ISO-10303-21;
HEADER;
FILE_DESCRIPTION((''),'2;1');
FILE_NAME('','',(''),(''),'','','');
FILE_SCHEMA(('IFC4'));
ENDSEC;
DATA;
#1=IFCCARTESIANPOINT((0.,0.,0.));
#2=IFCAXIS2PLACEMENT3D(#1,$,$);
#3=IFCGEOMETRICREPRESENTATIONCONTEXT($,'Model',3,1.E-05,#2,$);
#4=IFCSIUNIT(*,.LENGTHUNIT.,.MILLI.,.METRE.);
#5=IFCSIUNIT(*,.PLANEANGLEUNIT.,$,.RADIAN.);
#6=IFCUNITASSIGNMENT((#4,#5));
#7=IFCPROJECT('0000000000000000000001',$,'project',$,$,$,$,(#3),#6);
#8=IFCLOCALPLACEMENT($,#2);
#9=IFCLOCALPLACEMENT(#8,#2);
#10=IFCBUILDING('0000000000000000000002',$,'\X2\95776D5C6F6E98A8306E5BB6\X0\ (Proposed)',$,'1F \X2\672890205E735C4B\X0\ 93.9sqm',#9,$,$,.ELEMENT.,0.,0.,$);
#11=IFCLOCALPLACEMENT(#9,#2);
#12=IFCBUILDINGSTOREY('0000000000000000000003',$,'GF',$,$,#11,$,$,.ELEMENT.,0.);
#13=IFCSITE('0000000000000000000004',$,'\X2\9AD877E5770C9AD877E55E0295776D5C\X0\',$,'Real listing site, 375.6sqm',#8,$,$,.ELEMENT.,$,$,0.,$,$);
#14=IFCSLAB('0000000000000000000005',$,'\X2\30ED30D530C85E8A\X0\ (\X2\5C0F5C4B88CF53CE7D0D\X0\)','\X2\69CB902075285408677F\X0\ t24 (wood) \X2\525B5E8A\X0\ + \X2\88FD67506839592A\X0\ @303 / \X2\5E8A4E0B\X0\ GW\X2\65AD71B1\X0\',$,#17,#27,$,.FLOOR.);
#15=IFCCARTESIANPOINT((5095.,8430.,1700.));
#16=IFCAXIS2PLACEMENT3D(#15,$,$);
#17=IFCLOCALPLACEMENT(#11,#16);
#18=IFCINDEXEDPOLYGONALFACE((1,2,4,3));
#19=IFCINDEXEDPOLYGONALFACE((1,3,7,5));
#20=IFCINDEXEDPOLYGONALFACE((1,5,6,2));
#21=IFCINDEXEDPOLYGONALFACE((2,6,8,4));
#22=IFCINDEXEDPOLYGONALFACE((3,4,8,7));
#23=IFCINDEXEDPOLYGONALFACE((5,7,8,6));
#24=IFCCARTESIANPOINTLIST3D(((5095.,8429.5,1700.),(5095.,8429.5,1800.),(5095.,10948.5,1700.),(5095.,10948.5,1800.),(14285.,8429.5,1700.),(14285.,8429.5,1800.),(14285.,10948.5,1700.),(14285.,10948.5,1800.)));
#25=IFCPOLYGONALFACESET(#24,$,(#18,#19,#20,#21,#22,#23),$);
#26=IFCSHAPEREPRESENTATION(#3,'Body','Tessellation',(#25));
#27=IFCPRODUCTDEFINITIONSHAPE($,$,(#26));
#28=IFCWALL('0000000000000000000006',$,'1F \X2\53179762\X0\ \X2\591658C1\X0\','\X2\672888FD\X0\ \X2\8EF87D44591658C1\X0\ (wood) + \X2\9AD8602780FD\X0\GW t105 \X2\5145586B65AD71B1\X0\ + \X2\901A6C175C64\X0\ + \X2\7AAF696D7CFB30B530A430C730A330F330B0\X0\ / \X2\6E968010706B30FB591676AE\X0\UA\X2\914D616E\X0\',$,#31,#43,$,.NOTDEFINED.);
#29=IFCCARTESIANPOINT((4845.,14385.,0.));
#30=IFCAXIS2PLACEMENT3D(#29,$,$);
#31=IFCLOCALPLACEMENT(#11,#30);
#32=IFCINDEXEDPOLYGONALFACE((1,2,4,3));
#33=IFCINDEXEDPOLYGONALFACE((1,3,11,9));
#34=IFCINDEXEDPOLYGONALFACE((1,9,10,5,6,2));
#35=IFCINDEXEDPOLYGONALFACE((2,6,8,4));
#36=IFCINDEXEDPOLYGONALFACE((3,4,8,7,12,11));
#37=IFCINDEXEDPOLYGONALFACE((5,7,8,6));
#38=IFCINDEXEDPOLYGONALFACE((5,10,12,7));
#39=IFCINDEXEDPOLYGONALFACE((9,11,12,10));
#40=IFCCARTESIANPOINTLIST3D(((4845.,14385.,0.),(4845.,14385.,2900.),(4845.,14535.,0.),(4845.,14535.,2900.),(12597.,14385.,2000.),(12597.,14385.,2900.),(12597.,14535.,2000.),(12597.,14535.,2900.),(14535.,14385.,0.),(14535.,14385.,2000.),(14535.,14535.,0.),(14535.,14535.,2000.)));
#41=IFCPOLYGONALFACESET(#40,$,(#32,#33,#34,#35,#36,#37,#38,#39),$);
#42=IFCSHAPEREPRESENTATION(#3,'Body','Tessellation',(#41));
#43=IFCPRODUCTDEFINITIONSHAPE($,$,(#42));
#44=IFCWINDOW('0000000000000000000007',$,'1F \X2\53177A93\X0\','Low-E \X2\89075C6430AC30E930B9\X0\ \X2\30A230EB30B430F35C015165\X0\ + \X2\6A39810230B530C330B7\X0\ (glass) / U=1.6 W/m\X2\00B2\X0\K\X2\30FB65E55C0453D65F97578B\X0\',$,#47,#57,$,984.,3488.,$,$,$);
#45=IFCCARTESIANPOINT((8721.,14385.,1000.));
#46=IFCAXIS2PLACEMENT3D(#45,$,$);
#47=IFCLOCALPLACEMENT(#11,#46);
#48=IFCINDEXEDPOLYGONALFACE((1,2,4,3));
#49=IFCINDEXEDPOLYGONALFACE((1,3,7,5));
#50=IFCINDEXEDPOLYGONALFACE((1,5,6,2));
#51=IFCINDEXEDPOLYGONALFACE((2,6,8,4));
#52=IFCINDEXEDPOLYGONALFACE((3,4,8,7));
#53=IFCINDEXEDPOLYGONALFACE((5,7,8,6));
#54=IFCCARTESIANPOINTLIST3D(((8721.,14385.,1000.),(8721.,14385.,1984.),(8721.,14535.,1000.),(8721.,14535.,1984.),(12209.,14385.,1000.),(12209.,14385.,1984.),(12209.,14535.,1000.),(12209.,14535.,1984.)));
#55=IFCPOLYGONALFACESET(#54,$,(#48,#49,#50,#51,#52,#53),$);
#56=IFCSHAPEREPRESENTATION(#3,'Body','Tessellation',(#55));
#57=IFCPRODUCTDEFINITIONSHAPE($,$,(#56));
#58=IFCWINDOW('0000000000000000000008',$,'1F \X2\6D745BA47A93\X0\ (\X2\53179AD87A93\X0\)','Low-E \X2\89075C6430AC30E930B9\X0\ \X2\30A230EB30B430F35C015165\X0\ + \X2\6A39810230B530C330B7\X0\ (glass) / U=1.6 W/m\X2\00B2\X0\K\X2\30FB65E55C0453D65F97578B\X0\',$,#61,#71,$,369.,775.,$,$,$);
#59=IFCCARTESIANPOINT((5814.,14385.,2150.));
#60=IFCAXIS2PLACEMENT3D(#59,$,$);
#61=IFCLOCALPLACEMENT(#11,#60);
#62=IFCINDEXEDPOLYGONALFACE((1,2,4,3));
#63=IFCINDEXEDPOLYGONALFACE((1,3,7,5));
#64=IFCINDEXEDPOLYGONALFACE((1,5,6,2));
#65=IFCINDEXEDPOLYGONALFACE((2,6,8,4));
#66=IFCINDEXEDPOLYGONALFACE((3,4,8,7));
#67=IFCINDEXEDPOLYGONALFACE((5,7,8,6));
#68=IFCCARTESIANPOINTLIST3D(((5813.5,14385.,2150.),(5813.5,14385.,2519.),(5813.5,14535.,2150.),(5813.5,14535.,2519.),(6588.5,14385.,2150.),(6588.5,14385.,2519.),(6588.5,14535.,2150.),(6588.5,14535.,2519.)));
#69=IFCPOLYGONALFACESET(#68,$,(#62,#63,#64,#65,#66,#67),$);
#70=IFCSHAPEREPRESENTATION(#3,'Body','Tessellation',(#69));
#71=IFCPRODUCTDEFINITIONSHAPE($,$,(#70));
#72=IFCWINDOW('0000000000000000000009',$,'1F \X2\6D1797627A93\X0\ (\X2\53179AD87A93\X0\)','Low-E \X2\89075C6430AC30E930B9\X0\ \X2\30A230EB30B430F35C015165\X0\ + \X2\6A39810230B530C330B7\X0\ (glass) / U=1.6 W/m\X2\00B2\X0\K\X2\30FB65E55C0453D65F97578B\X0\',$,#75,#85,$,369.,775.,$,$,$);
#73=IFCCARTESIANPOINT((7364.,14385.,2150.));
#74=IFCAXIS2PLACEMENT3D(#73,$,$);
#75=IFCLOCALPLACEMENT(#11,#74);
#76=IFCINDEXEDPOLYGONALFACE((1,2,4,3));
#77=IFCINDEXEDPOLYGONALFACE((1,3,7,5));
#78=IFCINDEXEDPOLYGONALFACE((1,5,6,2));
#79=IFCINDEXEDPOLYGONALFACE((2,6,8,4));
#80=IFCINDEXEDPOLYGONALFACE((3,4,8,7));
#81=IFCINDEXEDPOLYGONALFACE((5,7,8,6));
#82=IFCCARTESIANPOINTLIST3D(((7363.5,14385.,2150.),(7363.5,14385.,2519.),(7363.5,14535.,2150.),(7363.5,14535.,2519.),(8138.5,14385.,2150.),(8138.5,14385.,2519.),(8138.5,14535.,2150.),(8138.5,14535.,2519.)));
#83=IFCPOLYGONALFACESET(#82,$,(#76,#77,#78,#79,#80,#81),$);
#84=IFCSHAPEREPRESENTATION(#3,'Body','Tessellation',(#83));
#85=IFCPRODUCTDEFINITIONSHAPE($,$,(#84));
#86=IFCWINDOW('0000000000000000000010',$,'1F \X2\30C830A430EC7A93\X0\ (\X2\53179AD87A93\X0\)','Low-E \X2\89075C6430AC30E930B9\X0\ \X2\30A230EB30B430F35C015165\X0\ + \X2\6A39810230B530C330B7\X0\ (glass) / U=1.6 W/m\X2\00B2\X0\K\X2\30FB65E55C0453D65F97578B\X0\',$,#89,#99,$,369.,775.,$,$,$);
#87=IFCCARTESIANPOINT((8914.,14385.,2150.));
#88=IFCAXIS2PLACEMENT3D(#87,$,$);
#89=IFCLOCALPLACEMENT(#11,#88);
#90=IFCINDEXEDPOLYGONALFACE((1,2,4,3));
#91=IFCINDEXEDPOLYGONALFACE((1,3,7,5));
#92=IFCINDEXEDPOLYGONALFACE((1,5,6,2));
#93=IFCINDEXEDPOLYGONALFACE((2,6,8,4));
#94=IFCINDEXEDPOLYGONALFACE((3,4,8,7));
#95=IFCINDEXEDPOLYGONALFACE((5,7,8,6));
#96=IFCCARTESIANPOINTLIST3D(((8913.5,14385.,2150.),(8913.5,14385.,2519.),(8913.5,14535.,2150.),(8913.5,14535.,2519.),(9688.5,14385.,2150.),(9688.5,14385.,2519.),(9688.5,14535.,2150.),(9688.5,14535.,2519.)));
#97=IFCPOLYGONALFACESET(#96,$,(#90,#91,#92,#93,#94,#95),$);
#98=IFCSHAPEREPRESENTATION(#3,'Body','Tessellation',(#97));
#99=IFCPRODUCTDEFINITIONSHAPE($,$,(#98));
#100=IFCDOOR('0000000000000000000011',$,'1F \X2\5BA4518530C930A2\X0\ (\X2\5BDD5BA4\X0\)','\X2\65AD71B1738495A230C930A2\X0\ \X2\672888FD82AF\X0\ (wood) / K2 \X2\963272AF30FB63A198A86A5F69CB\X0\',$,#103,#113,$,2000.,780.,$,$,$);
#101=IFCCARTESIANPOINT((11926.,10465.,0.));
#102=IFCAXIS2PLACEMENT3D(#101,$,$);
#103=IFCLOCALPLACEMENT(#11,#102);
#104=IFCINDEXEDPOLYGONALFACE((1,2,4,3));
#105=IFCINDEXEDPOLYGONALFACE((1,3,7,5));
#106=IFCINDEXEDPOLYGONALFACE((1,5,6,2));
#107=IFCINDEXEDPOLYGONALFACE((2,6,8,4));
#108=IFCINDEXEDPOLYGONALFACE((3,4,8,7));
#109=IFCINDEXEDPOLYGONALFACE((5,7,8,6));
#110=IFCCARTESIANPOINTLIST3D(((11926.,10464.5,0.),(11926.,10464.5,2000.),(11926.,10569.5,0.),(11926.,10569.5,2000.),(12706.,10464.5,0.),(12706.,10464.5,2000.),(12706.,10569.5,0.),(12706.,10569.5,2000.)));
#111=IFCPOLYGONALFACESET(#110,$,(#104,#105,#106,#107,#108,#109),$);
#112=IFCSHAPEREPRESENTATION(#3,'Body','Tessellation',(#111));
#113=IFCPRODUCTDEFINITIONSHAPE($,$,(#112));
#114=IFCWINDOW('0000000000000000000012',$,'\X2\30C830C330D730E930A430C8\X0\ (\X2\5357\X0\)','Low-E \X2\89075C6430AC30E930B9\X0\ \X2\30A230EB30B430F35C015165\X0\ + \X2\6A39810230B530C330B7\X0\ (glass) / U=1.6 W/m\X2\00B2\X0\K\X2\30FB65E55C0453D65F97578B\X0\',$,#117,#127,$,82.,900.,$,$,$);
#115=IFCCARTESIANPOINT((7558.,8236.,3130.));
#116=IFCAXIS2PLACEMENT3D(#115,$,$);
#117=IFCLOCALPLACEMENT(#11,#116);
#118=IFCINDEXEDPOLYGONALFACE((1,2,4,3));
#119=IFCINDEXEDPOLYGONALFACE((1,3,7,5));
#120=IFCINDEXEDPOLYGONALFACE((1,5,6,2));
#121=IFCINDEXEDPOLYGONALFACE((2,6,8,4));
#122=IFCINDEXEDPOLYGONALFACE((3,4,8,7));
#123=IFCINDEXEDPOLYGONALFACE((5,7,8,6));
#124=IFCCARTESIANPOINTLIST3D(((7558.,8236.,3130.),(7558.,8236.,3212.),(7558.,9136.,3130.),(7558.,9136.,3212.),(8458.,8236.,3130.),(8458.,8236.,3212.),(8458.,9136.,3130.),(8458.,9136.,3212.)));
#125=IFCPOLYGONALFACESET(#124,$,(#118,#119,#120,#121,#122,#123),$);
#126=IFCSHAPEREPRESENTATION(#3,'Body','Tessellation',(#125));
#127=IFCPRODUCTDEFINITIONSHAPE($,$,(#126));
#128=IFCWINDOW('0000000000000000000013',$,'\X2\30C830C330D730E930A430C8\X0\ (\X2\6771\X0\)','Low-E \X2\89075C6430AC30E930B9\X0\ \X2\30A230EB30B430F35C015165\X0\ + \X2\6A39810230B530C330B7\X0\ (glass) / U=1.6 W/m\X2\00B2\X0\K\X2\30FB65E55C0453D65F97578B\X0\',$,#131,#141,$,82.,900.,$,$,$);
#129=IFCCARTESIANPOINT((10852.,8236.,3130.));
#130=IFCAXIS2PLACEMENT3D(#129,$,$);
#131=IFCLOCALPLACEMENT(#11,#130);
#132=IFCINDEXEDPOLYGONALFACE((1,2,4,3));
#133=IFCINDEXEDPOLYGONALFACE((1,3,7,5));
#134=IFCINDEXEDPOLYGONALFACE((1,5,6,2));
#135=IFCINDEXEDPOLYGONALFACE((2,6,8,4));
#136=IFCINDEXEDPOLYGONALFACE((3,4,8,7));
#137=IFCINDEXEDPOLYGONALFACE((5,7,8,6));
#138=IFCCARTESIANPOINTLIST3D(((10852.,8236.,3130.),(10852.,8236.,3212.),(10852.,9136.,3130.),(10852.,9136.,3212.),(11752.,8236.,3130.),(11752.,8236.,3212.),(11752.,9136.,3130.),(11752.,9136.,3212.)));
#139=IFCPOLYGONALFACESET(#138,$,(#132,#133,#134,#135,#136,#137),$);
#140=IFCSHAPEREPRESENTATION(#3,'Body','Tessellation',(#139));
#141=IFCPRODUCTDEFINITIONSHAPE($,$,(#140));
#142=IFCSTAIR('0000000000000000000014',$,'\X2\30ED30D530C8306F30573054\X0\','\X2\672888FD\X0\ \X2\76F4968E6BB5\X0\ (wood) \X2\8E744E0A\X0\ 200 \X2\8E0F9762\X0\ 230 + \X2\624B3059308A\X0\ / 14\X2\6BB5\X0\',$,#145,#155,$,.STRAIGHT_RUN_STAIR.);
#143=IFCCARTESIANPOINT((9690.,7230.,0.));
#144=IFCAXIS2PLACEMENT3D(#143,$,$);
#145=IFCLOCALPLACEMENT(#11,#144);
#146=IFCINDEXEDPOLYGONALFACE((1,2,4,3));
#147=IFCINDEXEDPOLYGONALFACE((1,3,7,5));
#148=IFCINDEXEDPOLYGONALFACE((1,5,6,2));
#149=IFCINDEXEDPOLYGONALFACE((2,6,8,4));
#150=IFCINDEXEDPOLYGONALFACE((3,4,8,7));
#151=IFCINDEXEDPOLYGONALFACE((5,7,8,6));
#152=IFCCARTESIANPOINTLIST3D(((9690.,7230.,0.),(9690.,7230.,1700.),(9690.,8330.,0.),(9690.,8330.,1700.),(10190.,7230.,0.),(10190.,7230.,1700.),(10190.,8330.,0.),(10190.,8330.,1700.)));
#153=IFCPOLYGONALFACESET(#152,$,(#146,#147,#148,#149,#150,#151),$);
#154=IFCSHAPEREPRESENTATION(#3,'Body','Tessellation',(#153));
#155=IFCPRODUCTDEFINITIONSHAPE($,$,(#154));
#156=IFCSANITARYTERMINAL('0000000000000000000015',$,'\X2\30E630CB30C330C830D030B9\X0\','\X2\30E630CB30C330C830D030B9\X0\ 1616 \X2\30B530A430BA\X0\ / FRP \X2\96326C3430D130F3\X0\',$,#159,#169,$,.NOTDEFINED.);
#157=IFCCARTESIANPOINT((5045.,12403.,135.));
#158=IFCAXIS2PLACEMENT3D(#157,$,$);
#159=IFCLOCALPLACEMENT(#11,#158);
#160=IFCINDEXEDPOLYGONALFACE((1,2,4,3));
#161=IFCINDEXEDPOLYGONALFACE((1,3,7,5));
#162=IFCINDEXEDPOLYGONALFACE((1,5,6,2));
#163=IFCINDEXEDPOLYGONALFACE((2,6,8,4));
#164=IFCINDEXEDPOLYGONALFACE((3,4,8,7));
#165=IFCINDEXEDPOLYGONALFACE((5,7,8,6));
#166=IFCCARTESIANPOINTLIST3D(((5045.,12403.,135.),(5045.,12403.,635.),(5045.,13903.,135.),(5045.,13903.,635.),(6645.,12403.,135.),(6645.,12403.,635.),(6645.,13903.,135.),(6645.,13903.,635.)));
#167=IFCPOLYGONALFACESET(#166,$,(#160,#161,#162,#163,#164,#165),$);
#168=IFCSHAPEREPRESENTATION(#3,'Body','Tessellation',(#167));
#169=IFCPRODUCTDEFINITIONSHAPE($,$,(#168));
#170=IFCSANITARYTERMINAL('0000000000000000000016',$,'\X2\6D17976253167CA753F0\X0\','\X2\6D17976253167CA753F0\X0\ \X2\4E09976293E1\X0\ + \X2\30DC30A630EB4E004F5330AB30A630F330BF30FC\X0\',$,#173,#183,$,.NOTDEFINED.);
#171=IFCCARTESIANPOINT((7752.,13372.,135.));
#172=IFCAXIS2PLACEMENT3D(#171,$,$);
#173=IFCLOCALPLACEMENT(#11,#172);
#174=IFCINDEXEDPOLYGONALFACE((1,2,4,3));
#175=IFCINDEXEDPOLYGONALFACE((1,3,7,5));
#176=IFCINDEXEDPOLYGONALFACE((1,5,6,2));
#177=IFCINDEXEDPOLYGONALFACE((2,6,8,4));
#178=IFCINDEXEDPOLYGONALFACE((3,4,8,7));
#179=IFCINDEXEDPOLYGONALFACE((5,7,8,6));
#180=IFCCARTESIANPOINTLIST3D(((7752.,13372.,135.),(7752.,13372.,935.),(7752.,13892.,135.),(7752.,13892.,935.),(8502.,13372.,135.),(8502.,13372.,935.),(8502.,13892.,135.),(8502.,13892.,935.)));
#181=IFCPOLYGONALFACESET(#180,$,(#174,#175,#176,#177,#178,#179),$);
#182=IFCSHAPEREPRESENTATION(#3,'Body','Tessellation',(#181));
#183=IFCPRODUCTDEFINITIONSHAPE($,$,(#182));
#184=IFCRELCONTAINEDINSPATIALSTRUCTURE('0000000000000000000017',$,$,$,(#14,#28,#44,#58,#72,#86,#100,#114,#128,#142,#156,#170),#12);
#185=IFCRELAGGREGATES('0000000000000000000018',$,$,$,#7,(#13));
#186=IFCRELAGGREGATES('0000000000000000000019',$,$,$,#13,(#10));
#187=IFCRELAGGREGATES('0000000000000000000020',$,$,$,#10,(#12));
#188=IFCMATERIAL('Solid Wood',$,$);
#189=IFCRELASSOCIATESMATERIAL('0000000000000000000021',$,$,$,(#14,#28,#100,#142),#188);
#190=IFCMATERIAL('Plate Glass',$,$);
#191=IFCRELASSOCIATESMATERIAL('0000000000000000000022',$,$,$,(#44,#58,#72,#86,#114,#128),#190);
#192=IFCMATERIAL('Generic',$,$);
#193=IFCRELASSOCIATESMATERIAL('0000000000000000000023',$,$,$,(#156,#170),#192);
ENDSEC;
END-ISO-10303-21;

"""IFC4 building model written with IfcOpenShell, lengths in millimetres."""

from ifc_helpers import new_model, si_unit, frame, frame_2d, origin, place, context, project, spatial, rectangle, extrude, material, element, fill, save


model = new_model("IFC4")

# Units and contexts
model_context = context("Model", 3, precision=1e-05, world=origin())
ifc_project = project(units=[si_unit("LENGTHUNIT", "METRE", prefix="MILLI"), si_unit("PLANEANGLEUNIT", "RADIAN")], contexts=[model_context])

# Site, building, storey
site_placement = place(None, origin())
site = spatial("IfcSite", under=ifc_project, at=site_placement, Name="高知県高知市長浜", ObjectType="Real listing site, 375.6sqm", CompositionType="ELEMENT", RefElevation=0.0)
building_placement = place(site_placement, origin())
building = spatial("IfcBuilding", under=site, at=building_placement, Name="長浜潮風の家 (Proposed)", ObjectType="1F 木造平屋 93.9sqm", CompositionType="ELEMENT", ElevationOfRefHeight=0.0, ElevationOfTerrain=0.0)
storey_placement = place(building_placement, origin())
storey = spatial("IfcBuildingStorey", under=building, at=storey_placement, Name="GF", CompositionType="ELEMENT", Elevation=0.0)

# Slab
ifc_material_1 = material(Name="Solid Wood")
slab_placement = place(storey_placement, frame((5095.0, 8430.0, 1700.0)))
element("IfcSlab", 1, at=slab_placement, inside=storey, material=ifc_material_1, Name="ロフト床 (小屋裏収納)", Description="構造用合板 t24 (wood) 剛床 + 製材根太 @303 / 床下 GW断熱", PredefinedType="FLOOR", context=model_context, shape_type="SweptSolid", body=[
    extrude(rectangle(XDim=9190.0, YDim=2519.0, at=frame_2d((4595.0, 1259.0))), frame((5095.0, 8430.0, 1700.0)), (0.0, 0.0, 1.0), 100.0),
])

# Wall, openings, windows
wall_1_placement = place(storey_placement, frame((4845.0, 14385.0, 0.0)))
wall_1 = element("IfcWall", 2, at=wall_1_placement, inside=storey, material=ifc_material_1, Name="1F 北面 外壁", Description="木製 軸組外壁 (wood) + 高性能GW t105 充填断熱 + 通気層 + 窯業系サイディング / 準耐火・外皮UA配慮", PredefinedType="NOTDEFINED", context=model_context, shape_type="SweptSolid", body=[
    extrude(rectangle(XDim=9690.0, YDim=150.0, at=frame_2d((4845.0, 75.0))), frame((4845.0, 14385.0, 0.0)), (0.0, 0.0, 1.0), 2900.0),
])
opening_1_placement = place(storey_placement, frame((8721.0, 14385.0, 1000.0)))
opening_1 = element("IfcOpeningElement", 3, at=opening_1_placement, cuts=wall_1, PredefinedType="NOTDEFINED", context=model_context, shape_type="SweptSolid", body=[
    extrude(rectangle(XDim=3488.0, YDim=150.0, at=frame_2d((1744.0, 75.0))), frame((8721.0, 14385.0, 1000.0)), (0.0, 0.0, 1.0), 984.0),
])
opening_2_placement = place(storey_placement, frame((5814.0, 14385.0, 2150.0)))
opening_2 = element("IfcOpeningElement", 4, at=opening_2_placement, cuts=wall_1, PredefinedType="NOTDEFINED", context=model_context, shape_type="SweptSolid", body=[
    extrude(rectangle(XDim=775.0, YDim=150.0, at=frame_2d((387.0, 75.0))), frame((5814.0, 14385.0, 2150.0)), (0.0, 0.0, 1.0), 369.0),
])
opening_3_placement = place(storey_placement, frame((7364.0, 14385.0, 2150.0)))
opening_3 = element("IfcOpeningElement", 5, at=opening_3_placement, cuts=wall_1, PredefinedType="NOTDEFINED", context=model_context, shape_type="SweptSolid", body=[
    extrude(rectangle(XDim=775.0, YDim=150.0, at=frame_2d((387.0, 75.0))), frame((7364.0, 14385.0, 2150.0)), (0.0, 0.0, 1.0), 369.0),
])
opening_4_placement = place(storey_placement, frame((8914.0, 14385.0, 2150.0)))
opening_4 = element("IfcOpeningElement", 6, at=opening_4_placement, cuts=wall_1, PredefinedType="NOTDEFINED", context=model_context, shape_type="SweptSolid", body=[
    extrude(rectangle(XDim=775.0, YDim=150.0, at=frame_2d((387.0, 75.0))), frame((8914.0, 14385.0, 2150.0)), (0.0, 0.0, 1.0), 369.0),
])
ifc_material_2 = material(Name="Plate Glass")
window_1_placement = place(storey_placement, frame((8721.0, 14385.0, 1000.0)))
window_1 = element("IfcWindow", 7, at=window_1_placement, inside=storey, material=ifc_material_2, Name="1F 北窓", Description="Low-E 複層ガラス アルゴン封入 + 樹脂サッシ (glass) / U=1.6 W/m²K・日射取得型", OverallHeight=984.0, OverallWidth=3488.0, context=model_context, shape_type="SweptSolid", body=[
    extrude(rectangle(XDim=3488.0, YDim=150.0, at=frame_2d((1744.0, 75.0))), frame((8721.0, 14385.0, 1000.0)), (0.0, 0.0, 1.0), 984.0),
])
fill(opening_1, window_1)
window_2_placement = place(storey_placement, frame((5814.0, 14385.0, 2150.0)))
window_2 = element("IfcWindow", 8, at=window_2_placement, inside=storey, material=ifc_material_2, Name="1F 浴室窓 (北高窓)", Description="Low-E 複層ガラス アルゴン封入 + 樹脂サッシ (glass) / U=1.6 W/m²K・日射取得型", OverallHeight=369.0, OverallWidth=775.0, context=model_context, shape_type="SweptSolid", body=[
    extrude(rectangle(XDim=775.0, YDim=150.0, at=frame_2d((387.0, 75.0))), frame((5814.0, 14385.0, 2150.0)), (0.0, 0.0, 1.0), 369.0),
])
fill(opening_2, window_2)
window_3_placement = place(storey_placement, frame((7364.0, 14385.0, 2150.0)))
window_3 = element("IfcWindow", 9, at=window_3_placement, inside=storey, material=ifc_material_2, Name="1F 洗面窓 (北高窓)", Description="Low-E 複層ガラス アルゴン封入 + 樹脂サッシ (glass) / U=1.6 W/m²K・日射取得型", OverallHeight=369.0, OverallWidth=775.0, context=model_context, shape_type="SweptSolid", body=[
    extrude(rectangle(XDim=775.0, YDim=150.0, at=frame_2d((387.0, 75.0))), frame((7364.0, 14385.0, 2150.0)), (0.0, 0.0, 1.0), 369.0),
])
fill(opening_3, window_3)
window_4_placement = place(storey_placement, frame((8914.0, 14385.0, 2150.0)))
window_4 = element("IfcWindow", 10, at=window_4_placement, inside=storey, material=ifc_material_2, Name="1F トイレ窓 (北高窓)", Description="Low-E 複層ガラス アルゴン封入 + 樹脂サッシ (glass) / U=1.6 W/m²K・日射取得型", OverallHeight=369.0, OverallWidth=775.0, context=model_context, shape_type="SweptSolid", body=[
    extrude(rectangle(XDim=775.0, YDim=150.0, at=frame_2d((387.0, 75.0))), frame((8914.0, 14385.0, 2150.0)), (0.0, 0.0, 1.0), 369.0),
])
fill(opening_4, window_4)

# Door
door_1_placement = place(storey_placement, frame((11926.0, 10465.0, 0.0)))
element("IfcDoor", 11, at=door_1_placement, inside=storey, material=ifc_material_1, Name="1F 室内ドア (寝室)", Description="断熱玄関ドア 木製芯 (wood) / K2 防犯・採風機構", OverallHeight=2000.0, OverallWidth=780.0, context=model_context, shape_type="SweptSolid", body=[
    extrude(rectangle(XDim=780.0, YDim=105.0, at=frame_2d((390.0, 52.0))), frame((11926.0, 10465.0, 0.0)), (0.0, 0.0, 1.0), 2000.0),
])

# Windows
window_5_placement = place(storey_placement, frame((7558.0, 8236.0, 3130.0)))
element("IfcWindow", 12, at=window_5_placement, inside=storey, material=ifc_material_2, Name="トップライト (南)", Description="Low-E 複層ガラス アルゴン封入 + 樹脂サッシ (glass) / U=1.6 W/m²K・日射取得型", OverallHeight=82.0, OverallWidth=900.0, context=model_context, shape_type="SweptSolid", body=[
    extrude(rectangle(XDim=900.0, YDim=900.0, at=frame_2d((450.0, 450.0))), frame((7558.0, 8236.0, 3130.0)), (0.0, 0.0, 1.0), 82.0),
])
window_6_placement = place(storey_placement, frame((10852.0, 8236.0, 3130.0)))
element("IfcWindow", 13, at=window_6_placement, inside=storey, material=ifc_material_2, Name="トップライト (東)", Description="Low-E 複層ガラス アルゴン封入 + 樹脂サッシ (glass) / U=1.6 W/m²K・日射取得型", OverallHeight=82.0, OverallWidth=900.0, context=model_context, shape_type="SweptSolid", body=[
    extrude(rectangle(XDim=900.0, YDim=900.0, at=frame_2d((450.0, 450.0))), frame((10852.0, 8236.0, 3130.0)), (0.0, 0.0, 1.0), 82.0),
])

# Stair
stair_placement = place(storey_placement, frame((9690.0, 7230.0, 0.0)))
element("IfcStair", 14, at=stair_placement, inside=storey, material=ifc_material_1, Name="ロフトはしご", Description="木製 直階段 (wood) 蹴上 200 踏面 230 + 手すり / 14段", PredefinedType="STRAIGHT_RUN_STAIR", context=model_context, shape_type="SweptSolid", body=[
    extrude(rectangle(XDim=500.0, YDim=1100.0, at=frame_2d((250.0, 550.0))), frame((9690.0, 7230.0, 0.0)), (0.0, 0.0, 1.0), 1700.0),
])

# Sanitary terminals
ifc_material_3 = material(Name="Generic")
sanitary_terminal_1_placement = place(storey_placement, frame((5045.0, 12403.0, 135.0)))
element("IfcSanitaryTerminal", 15, at=sanitary_terminal_1_placement, inside=storey, material=ifc_material_3, Name="ユニットバス", Description="ユニットバス 1616 サイズ / FRP 防水パン", PredefinedType="NOTDEFINED", context=model_context, shape_type="SweptSolid", body=[
    extrude(rectangle(XDim=1600.0, YDim=1500.0, at=frame_2d((800.0, 750.0))), frame((5045.0, 12403.0, 135.0)), (0.0, 0.0, 1.0), 500.0),
])
sanitary_terminal_2_placement = place(storey_placement, frame((7752.0, 13372.0, 135.0)))
element("IfcSanitaryTerminal", 16, at=sanitary_terminal_2_placement, inside=storey, material=ifc_material_3, Name="洗面化粧台", Description="洗面化粧台 三面鏡 + ボウル一体カウンター", PredefinedType="NOTDEFINED", context=model_context, shape_type="SweptSolid", body=[
    extrude(rectangle(XDim=750.0, YDim=520.0, at=frame_2d((375.0, 260.0))), frame((7752.0, 13372.0, 135.0)), (0.0, 0.0, 1.0), 800.0),
])

save(model, "model.ifc")
